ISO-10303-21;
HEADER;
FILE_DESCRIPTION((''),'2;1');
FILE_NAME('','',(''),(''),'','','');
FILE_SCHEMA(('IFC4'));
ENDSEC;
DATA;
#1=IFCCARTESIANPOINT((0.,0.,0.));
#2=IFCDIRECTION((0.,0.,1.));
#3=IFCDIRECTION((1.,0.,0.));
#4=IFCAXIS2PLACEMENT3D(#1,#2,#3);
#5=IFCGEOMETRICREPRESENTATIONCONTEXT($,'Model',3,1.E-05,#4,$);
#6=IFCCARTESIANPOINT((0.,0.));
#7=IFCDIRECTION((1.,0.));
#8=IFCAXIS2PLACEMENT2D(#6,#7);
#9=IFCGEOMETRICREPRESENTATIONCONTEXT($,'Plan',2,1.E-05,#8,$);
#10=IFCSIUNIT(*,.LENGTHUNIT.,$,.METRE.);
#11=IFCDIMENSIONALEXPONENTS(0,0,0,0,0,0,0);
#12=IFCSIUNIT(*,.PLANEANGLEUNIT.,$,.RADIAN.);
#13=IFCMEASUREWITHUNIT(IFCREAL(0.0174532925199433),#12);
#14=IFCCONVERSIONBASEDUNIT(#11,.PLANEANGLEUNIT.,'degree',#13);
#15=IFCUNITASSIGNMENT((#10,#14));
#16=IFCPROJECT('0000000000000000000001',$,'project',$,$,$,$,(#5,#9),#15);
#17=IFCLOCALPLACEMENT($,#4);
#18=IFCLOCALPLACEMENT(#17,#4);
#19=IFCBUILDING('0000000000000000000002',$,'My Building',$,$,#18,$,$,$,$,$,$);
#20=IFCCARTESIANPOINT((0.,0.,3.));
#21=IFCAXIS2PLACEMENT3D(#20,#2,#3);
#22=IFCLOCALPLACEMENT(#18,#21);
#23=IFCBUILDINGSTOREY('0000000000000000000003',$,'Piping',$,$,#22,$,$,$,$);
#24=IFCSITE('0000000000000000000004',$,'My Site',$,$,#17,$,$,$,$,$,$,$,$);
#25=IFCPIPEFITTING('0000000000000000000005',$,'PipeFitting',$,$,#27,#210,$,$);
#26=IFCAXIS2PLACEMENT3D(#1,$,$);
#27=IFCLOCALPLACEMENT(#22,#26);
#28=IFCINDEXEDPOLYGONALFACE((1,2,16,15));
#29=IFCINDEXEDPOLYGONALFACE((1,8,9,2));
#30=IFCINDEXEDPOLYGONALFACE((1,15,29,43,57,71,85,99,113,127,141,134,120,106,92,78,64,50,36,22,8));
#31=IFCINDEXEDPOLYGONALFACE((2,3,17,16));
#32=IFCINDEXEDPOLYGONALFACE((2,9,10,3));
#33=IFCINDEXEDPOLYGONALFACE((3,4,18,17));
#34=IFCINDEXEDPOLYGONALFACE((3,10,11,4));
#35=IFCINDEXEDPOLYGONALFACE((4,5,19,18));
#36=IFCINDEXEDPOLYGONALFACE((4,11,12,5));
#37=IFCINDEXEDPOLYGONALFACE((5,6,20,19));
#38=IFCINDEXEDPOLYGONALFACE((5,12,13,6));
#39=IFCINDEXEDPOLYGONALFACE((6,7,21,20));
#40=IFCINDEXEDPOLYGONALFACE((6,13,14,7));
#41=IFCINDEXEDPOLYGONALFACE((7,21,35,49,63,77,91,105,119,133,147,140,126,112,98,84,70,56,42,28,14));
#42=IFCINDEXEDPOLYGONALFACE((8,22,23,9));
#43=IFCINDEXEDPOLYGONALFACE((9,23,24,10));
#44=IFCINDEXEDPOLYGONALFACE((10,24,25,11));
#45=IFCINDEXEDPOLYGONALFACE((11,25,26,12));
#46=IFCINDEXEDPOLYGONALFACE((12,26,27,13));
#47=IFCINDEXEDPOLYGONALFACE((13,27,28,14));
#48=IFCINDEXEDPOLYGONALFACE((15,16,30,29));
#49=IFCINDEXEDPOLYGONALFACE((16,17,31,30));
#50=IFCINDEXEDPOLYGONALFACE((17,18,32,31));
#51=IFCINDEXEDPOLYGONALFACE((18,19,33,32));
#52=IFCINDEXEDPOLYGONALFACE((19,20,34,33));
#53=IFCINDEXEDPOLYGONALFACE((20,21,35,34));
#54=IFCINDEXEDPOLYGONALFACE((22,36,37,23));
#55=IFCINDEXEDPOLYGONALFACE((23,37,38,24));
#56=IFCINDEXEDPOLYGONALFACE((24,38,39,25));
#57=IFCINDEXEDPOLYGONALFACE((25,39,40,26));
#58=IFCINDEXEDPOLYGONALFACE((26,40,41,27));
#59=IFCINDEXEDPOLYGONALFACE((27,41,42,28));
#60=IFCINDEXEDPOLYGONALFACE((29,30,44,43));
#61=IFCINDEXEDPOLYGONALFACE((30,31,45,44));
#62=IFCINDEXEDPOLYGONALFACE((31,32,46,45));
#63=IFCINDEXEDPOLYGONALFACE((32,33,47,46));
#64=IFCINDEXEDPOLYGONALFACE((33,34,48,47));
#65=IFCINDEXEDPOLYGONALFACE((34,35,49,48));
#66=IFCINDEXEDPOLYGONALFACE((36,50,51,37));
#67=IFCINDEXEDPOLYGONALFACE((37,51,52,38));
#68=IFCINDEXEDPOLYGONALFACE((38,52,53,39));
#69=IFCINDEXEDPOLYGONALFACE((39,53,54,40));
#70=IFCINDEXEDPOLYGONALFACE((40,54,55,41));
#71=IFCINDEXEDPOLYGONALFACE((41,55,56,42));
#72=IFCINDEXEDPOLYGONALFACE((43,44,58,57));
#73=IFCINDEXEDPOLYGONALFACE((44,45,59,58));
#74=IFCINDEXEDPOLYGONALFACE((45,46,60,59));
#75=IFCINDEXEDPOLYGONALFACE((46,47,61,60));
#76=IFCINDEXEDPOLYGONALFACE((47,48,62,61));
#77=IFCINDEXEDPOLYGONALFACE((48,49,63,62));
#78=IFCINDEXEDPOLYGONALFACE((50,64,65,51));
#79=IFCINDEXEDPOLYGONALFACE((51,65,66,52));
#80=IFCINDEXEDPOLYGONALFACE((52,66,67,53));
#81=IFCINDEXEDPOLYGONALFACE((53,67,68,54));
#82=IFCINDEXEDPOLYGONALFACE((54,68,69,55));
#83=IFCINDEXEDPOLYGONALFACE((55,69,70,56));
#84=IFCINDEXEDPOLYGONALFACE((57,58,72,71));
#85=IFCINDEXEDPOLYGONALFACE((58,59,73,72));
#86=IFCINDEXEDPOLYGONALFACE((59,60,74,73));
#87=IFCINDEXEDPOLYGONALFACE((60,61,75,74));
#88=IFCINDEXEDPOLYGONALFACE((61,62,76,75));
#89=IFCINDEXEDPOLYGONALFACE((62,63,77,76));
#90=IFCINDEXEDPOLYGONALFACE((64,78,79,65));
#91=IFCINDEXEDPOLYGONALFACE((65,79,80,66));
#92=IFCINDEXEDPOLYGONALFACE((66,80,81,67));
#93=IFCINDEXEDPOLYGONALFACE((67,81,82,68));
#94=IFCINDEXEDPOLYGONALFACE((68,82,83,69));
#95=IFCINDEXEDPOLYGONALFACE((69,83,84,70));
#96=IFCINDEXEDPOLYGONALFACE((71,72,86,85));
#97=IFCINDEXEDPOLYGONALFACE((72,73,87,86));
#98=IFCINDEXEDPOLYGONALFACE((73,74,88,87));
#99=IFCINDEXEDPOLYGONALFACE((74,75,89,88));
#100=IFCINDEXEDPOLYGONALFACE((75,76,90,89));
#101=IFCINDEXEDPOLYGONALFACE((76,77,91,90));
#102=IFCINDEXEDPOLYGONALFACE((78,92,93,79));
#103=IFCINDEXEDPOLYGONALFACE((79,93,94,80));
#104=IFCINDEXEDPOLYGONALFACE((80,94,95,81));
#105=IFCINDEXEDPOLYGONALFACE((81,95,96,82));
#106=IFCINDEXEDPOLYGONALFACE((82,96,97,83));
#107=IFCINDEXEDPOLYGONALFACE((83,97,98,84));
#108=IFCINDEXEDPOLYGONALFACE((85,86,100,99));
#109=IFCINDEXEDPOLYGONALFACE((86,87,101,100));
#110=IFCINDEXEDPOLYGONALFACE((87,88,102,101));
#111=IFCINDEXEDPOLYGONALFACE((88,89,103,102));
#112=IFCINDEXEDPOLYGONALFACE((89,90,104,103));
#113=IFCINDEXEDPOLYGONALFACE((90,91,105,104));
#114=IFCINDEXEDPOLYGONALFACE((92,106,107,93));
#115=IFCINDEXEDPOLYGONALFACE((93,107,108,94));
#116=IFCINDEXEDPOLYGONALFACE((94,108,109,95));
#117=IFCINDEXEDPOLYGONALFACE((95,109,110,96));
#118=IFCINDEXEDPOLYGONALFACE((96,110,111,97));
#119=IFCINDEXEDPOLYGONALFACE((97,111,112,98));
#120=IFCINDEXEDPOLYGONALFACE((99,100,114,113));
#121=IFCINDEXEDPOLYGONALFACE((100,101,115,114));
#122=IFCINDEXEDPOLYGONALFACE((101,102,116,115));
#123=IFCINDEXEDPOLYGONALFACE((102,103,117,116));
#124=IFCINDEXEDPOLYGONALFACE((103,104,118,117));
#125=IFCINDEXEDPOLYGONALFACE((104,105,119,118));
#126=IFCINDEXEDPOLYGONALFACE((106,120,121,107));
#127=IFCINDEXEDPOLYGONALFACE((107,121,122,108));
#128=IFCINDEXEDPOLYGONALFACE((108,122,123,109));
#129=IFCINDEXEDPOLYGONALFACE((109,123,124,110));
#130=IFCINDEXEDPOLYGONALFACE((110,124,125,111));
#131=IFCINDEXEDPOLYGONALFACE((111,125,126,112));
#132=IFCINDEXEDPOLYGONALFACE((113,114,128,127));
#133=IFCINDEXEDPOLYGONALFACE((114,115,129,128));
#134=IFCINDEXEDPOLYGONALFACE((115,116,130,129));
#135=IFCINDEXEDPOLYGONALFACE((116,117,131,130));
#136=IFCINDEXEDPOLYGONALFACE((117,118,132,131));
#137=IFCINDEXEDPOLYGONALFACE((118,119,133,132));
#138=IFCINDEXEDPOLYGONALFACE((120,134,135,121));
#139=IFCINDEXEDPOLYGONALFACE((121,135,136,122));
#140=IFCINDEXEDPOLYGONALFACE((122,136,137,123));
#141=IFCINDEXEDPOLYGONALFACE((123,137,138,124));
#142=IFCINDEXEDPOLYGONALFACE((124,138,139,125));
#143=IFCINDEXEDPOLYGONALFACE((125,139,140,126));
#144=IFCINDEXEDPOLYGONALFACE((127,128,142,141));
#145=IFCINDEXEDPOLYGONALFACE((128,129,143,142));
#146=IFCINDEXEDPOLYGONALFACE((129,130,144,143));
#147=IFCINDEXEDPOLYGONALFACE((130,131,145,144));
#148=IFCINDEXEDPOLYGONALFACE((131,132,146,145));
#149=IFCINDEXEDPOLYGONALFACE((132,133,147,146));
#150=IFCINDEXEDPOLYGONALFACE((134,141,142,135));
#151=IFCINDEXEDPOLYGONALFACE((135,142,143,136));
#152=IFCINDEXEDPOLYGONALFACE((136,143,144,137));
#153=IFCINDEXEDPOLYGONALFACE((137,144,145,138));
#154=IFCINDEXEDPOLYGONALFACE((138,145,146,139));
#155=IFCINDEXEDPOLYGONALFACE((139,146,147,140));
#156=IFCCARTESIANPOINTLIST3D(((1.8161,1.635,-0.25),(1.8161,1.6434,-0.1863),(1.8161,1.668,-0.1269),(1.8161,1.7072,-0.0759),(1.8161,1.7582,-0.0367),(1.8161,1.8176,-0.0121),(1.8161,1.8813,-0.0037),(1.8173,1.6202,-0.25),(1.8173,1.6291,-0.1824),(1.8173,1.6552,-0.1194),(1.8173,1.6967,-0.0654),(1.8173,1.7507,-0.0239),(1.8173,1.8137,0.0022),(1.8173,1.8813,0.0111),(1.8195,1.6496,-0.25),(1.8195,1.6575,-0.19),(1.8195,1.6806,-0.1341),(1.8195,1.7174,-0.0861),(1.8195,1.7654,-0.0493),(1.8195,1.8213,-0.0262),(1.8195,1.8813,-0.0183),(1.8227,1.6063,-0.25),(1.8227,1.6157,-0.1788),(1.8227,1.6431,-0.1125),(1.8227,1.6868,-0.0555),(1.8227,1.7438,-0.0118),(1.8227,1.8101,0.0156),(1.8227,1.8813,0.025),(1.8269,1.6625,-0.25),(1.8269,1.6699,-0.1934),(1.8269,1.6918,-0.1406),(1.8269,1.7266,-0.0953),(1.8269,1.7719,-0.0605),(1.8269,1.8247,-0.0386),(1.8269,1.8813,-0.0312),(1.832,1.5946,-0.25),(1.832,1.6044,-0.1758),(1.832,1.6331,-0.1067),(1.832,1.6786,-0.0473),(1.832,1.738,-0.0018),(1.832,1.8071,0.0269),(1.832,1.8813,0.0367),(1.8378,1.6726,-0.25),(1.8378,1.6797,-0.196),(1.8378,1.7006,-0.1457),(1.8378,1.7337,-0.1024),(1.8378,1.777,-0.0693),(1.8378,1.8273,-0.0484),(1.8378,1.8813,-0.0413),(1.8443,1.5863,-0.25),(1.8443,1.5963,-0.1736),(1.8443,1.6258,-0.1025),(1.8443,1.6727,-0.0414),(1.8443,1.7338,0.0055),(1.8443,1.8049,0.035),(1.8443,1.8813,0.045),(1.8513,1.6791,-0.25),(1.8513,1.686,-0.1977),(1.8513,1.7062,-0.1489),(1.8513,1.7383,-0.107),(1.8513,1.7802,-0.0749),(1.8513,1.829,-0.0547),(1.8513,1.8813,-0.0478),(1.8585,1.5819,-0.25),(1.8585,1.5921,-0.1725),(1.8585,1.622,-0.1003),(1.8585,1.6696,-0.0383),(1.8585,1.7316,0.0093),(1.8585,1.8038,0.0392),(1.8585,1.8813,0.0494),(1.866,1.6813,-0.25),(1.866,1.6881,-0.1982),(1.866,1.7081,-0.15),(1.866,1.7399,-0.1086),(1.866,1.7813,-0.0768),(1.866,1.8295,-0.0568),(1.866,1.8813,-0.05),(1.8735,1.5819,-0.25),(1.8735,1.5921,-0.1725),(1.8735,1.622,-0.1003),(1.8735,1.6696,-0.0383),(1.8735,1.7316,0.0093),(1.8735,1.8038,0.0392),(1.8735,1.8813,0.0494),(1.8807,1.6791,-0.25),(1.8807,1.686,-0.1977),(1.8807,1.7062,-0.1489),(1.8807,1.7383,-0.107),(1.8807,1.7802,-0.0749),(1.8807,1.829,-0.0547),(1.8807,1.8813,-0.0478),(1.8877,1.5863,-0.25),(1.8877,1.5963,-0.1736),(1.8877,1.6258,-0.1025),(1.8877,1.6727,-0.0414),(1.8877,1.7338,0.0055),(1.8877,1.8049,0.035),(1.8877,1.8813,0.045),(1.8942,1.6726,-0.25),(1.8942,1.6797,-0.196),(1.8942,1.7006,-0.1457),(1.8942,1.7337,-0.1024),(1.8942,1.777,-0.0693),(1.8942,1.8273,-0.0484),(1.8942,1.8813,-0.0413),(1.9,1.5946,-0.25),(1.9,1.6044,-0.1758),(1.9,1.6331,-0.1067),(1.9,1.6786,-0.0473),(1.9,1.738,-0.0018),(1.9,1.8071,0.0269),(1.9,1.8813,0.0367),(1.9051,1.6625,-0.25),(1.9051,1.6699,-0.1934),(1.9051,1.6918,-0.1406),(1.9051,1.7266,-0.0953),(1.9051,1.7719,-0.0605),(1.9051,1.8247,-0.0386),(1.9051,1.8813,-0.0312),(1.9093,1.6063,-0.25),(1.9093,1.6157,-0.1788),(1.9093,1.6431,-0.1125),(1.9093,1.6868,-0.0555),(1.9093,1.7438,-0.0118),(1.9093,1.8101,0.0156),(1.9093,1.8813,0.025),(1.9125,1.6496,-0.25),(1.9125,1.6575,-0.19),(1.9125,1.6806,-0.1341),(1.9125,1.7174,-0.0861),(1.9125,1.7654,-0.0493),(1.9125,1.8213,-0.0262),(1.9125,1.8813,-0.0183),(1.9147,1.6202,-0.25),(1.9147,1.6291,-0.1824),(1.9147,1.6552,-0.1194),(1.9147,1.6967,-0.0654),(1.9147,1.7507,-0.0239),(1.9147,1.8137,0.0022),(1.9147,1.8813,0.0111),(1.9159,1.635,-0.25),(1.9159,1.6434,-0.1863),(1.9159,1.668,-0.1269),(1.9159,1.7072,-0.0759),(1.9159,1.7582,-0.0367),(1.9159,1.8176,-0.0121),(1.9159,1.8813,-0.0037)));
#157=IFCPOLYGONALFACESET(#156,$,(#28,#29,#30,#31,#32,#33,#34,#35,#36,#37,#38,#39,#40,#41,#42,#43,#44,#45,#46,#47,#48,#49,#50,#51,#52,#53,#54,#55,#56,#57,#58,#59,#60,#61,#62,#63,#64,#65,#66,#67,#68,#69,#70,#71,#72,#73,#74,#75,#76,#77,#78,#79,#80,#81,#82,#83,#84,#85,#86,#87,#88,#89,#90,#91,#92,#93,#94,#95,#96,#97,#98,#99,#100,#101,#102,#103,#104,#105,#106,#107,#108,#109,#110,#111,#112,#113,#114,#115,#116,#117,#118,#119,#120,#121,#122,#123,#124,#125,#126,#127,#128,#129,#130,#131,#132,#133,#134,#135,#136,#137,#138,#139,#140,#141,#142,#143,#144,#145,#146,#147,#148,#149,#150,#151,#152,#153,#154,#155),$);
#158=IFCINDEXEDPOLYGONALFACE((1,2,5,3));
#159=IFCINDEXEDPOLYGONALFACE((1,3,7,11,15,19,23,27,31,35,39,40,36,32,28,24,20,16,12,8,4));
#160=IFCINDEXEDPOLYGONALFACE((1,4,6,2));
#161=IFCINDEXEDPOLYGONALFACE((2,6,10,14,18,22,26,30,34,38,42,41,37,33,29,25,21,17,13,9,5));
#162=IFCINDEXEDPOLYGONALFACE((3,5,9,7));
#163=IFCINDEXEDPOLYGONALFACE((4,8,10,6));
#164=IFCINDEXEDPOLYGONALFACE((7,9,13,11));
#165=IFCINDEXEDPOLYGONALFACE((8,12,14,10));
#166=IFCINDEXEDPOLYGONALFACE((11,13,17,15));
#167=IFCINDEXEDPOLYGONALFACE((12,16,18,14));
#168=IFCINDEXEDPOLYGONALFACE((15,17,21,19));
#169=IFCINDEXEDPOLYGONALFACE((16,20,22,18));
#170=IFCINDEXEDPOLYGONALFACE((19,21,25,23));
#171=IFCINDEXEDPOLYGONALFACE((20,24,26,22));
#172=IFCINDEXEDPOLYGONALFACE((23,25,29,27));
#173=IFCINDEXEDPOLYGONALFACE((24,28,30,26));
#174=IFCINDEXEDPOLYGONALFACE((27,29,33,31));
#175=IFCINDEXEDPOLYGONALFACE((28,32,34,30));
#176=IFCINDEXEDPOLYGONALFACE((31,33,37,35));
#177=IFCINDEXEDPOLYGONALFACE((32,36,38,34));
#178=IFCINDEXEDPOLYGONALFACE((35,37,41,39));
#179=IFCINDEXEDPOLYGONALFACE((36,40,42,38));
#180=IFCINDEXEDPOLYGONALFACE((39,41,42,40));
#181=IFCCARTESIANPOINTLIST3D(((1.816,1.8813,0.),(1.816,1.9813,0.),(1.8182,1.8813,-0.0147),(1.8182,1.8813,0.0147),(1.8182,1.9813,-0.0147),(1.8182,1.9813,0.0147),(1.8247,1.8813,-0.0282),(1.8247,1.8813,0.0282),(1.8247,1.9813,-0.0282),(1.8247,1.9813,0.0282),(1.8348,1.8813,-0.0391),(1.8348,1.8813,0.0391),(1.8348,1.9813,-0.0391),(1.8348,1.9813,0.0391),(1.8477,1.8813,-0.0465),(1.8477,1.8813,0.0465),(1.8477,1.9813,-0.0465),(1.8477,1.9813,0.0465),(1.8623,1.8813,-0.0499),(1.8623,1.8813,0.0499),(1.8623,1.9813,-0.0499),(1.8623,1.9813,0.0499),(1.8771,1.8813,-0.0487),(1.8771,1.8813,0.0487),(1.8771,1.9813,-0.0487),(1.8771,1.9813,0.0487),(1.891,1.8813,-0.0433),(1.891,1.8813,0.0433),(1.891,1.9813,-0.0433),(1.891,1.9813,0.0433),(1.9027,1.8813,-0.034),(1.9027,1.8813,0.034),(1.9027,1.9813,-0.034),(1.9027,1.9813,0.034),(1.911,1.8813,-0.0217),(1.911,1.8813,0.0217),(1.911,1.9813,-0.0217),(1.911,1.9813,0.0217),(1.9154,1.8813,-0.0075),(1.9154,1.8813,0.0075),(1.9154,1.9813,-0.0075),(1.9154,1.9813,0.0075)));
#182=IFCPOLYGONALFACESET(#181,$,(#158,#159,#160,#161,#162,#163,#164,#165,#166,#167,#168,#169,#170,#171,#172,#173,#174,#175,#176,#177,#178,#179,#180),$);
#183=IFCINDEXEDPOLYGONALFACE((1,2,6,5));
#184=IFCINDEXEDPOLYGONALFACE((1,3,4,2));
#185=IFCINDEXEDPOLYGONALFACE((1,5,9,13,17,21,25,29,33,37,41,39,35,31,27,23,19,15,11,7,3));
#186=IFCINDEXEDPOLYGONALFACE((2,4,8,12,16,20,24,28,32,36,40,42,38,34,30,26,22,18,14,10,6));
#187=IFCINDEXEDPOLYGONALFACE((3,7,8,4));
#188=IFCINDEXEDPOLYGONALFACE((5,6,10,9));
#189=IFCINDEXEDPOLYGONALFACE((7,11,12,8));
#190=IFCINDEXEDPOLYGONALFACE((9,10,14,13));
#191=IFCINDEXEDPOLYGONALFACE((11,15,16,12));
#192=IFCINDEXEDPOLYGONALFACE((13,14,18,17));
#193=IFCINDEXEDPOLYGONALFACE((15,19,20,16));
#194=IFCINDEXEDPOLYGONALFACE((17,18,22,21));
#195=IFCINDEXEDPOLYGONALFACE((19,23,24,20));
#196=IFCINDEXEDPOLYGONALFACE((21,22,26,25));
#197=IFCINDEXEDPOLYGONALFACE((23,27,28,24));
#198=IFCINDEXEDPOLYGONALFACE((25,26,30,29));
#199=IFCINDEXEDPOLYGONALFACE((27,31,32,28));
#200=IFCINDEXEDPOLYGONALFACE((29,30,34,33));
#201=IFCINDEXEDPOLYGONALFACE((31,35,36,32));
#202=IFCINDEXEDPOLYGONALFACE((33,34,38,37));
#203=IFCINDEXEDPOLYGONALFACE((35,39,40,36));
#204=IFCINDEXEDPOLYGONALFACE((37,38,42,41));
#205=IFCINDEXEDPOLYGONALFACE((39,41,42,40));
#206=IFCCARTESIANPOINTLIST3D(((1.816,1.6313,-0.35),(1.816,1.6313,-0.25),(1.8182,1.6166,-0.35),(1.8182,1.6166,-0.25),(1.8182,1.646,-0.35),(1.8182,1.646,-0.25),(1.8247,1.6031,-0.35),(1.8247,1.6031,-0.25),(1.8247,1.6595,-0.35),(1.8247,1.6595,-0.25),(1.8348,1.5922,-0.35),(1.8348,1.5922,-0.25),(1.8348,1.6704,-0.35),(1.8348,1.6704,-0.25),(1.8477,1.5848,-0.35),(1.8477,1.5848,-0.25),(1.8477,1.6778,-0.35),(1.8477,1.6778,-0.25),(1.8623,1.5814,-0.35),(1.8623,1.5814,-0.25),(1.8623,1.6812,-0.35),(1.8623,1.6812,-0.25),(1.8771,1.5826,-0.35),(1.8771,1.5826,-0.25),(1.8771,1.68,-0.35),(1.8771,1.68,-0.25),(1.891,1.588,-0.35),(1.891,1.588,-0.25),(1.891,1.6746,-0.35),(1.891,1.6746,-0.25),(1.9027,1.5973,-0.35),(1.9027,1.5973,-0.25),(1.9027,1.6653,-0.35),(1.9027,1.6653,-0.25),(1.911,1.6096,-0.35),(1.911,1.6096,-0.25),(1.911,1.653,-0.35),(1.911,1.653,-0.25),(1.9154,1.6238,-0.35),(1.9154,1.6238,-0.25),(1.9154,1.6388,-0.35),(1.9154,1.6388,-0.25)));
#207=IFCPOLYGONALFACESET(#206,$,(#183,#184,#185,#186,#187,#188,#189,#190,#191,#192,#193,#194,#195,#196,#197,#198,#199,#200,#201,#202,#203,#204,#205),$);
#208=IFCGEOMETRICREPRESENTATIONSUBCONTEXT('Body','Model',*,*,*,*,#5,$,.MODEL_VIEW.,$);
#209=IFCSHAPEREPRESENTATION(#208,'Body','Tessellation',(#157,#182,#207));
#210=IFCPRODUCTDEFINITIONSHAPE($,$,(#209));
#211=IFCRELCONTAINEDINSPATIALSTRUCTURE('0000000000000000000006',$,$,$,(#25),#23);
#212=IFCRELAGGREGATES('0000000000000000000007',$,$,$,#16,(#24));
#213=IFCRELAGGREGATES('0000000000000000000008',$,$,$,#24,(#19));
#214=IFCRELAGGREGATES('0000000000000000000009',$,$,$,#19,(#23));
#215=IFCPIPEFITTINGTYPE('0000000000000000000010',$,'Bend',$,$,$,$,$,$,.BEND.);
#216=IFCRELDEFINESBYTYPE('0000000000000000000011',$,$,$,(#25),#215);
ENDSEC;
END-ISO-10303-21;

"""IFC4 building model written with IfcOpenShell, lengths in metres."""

from ifc_helpers import new_model, entity, si_unit, converted_unit, frame, origin_with_axes, origin_2d_with_axis, place, context, subcontext, project, spatial, circle, extrude, source, transform, mapped, type_object, type_shapes, element, save


model = new_model("IFC4")

# Units and contexts
model_context = context("Model", 3, precision=1e-05, world=origin_with_axes())
plan_context = context("Plan", 2, precision=1e-05, world=origin_2d_with_axis())
body_context = subcontext(model_context, "Body", "Model", "MODEL_VIEW")
ifc_project = project(units=[si_unit("LENGTHUNIT", "METRE"), converted_unit("PLANEANGLEUNIT", "degree", entity("IfcReal", 0.0174532925199433), si_unit("PLANEANGLEUNIT", "RADIAN"), dimensions=[0, 0, 0, 0, 0, 0, 0])], contexts=[model_context, plan_context])

# Site, building, storey
site_placement = place(None, origin_with_axes())
site = spatial("IfcSite", under=ifc_project, at=site_placement, Name="My Site")
building_placement = place(site_placement, origin_with_axes())
building = spatial("IfcBuilding", under=site, at=building_placement, Name="My Building")
storey_placement = place(building_placement, frame((0.0, 0.0, 3.0), z_axis=(0.0, 0.0, 1.0), x_axis=(1.0, 0.0, 0.0)))
storey = spatial("IfcBuildingStorey", under=building, at=storey_placement, Name="Piping")

# Pipe fitting
pipe_fitting_type = type_object("IfcPipeFittingType", Name="Bend", PredefinedType="BEND")
shared_shape = source(origin_with_axes(), body_context, "Body", "SolidModel", [
    entity("IfcSweptDiskSolid", entity("IfcIndexedPolyCurve", entity("IfcCartesianPointList3D", [[0.0, 0.0, -0.1], [0.0, -0.0732, -0.2768], [0.0, -0.25, -0.35]]), [entity("IfcArcIndex", [1, 2, 3])]), 0.05),
    extrude(circle(Radius=0.05), origin_with_axes(), (0.0, 0.0, -1.0), 0.1),
    extrude(circle(Radius=0.05), frame((0.0, -0.25, -0.35), z_axis=(0.0, -1.0, 0.0), x_axis=(1.0, 0.0, 0.0)), (0.0, 0.0, 1.0), 0.1),
])
type_shapes(pipe_fitting_type, [shared_shape])
for number, where, z_axis, x_axis, name in (
    (1, (1.866, 1.9813, 0.0), (0.0, 1.0, 0.0), (-1.0, 0.0, 0.0), "PipeFitting"),
):
    element("IfcPipeFitting", number, at=place(storey_placement, frame(where, z_axis=z_axis, x_axis=x_axis)), inside=storey, type_object=pipe_fitting_type, Name=name, context=body_context, shape_type="MappedRepresentation", body=[
        mapped(shared_shape, transform((0.0, 0.0, 0.0), x_axis=(1.0, 0.0, 0.0), y_axis=(0.0, 1.0, 0.0), z_axis=(0.0, 0.0, 1.0), scale=1.0)),
    ])

save(model, "model.ifc")
